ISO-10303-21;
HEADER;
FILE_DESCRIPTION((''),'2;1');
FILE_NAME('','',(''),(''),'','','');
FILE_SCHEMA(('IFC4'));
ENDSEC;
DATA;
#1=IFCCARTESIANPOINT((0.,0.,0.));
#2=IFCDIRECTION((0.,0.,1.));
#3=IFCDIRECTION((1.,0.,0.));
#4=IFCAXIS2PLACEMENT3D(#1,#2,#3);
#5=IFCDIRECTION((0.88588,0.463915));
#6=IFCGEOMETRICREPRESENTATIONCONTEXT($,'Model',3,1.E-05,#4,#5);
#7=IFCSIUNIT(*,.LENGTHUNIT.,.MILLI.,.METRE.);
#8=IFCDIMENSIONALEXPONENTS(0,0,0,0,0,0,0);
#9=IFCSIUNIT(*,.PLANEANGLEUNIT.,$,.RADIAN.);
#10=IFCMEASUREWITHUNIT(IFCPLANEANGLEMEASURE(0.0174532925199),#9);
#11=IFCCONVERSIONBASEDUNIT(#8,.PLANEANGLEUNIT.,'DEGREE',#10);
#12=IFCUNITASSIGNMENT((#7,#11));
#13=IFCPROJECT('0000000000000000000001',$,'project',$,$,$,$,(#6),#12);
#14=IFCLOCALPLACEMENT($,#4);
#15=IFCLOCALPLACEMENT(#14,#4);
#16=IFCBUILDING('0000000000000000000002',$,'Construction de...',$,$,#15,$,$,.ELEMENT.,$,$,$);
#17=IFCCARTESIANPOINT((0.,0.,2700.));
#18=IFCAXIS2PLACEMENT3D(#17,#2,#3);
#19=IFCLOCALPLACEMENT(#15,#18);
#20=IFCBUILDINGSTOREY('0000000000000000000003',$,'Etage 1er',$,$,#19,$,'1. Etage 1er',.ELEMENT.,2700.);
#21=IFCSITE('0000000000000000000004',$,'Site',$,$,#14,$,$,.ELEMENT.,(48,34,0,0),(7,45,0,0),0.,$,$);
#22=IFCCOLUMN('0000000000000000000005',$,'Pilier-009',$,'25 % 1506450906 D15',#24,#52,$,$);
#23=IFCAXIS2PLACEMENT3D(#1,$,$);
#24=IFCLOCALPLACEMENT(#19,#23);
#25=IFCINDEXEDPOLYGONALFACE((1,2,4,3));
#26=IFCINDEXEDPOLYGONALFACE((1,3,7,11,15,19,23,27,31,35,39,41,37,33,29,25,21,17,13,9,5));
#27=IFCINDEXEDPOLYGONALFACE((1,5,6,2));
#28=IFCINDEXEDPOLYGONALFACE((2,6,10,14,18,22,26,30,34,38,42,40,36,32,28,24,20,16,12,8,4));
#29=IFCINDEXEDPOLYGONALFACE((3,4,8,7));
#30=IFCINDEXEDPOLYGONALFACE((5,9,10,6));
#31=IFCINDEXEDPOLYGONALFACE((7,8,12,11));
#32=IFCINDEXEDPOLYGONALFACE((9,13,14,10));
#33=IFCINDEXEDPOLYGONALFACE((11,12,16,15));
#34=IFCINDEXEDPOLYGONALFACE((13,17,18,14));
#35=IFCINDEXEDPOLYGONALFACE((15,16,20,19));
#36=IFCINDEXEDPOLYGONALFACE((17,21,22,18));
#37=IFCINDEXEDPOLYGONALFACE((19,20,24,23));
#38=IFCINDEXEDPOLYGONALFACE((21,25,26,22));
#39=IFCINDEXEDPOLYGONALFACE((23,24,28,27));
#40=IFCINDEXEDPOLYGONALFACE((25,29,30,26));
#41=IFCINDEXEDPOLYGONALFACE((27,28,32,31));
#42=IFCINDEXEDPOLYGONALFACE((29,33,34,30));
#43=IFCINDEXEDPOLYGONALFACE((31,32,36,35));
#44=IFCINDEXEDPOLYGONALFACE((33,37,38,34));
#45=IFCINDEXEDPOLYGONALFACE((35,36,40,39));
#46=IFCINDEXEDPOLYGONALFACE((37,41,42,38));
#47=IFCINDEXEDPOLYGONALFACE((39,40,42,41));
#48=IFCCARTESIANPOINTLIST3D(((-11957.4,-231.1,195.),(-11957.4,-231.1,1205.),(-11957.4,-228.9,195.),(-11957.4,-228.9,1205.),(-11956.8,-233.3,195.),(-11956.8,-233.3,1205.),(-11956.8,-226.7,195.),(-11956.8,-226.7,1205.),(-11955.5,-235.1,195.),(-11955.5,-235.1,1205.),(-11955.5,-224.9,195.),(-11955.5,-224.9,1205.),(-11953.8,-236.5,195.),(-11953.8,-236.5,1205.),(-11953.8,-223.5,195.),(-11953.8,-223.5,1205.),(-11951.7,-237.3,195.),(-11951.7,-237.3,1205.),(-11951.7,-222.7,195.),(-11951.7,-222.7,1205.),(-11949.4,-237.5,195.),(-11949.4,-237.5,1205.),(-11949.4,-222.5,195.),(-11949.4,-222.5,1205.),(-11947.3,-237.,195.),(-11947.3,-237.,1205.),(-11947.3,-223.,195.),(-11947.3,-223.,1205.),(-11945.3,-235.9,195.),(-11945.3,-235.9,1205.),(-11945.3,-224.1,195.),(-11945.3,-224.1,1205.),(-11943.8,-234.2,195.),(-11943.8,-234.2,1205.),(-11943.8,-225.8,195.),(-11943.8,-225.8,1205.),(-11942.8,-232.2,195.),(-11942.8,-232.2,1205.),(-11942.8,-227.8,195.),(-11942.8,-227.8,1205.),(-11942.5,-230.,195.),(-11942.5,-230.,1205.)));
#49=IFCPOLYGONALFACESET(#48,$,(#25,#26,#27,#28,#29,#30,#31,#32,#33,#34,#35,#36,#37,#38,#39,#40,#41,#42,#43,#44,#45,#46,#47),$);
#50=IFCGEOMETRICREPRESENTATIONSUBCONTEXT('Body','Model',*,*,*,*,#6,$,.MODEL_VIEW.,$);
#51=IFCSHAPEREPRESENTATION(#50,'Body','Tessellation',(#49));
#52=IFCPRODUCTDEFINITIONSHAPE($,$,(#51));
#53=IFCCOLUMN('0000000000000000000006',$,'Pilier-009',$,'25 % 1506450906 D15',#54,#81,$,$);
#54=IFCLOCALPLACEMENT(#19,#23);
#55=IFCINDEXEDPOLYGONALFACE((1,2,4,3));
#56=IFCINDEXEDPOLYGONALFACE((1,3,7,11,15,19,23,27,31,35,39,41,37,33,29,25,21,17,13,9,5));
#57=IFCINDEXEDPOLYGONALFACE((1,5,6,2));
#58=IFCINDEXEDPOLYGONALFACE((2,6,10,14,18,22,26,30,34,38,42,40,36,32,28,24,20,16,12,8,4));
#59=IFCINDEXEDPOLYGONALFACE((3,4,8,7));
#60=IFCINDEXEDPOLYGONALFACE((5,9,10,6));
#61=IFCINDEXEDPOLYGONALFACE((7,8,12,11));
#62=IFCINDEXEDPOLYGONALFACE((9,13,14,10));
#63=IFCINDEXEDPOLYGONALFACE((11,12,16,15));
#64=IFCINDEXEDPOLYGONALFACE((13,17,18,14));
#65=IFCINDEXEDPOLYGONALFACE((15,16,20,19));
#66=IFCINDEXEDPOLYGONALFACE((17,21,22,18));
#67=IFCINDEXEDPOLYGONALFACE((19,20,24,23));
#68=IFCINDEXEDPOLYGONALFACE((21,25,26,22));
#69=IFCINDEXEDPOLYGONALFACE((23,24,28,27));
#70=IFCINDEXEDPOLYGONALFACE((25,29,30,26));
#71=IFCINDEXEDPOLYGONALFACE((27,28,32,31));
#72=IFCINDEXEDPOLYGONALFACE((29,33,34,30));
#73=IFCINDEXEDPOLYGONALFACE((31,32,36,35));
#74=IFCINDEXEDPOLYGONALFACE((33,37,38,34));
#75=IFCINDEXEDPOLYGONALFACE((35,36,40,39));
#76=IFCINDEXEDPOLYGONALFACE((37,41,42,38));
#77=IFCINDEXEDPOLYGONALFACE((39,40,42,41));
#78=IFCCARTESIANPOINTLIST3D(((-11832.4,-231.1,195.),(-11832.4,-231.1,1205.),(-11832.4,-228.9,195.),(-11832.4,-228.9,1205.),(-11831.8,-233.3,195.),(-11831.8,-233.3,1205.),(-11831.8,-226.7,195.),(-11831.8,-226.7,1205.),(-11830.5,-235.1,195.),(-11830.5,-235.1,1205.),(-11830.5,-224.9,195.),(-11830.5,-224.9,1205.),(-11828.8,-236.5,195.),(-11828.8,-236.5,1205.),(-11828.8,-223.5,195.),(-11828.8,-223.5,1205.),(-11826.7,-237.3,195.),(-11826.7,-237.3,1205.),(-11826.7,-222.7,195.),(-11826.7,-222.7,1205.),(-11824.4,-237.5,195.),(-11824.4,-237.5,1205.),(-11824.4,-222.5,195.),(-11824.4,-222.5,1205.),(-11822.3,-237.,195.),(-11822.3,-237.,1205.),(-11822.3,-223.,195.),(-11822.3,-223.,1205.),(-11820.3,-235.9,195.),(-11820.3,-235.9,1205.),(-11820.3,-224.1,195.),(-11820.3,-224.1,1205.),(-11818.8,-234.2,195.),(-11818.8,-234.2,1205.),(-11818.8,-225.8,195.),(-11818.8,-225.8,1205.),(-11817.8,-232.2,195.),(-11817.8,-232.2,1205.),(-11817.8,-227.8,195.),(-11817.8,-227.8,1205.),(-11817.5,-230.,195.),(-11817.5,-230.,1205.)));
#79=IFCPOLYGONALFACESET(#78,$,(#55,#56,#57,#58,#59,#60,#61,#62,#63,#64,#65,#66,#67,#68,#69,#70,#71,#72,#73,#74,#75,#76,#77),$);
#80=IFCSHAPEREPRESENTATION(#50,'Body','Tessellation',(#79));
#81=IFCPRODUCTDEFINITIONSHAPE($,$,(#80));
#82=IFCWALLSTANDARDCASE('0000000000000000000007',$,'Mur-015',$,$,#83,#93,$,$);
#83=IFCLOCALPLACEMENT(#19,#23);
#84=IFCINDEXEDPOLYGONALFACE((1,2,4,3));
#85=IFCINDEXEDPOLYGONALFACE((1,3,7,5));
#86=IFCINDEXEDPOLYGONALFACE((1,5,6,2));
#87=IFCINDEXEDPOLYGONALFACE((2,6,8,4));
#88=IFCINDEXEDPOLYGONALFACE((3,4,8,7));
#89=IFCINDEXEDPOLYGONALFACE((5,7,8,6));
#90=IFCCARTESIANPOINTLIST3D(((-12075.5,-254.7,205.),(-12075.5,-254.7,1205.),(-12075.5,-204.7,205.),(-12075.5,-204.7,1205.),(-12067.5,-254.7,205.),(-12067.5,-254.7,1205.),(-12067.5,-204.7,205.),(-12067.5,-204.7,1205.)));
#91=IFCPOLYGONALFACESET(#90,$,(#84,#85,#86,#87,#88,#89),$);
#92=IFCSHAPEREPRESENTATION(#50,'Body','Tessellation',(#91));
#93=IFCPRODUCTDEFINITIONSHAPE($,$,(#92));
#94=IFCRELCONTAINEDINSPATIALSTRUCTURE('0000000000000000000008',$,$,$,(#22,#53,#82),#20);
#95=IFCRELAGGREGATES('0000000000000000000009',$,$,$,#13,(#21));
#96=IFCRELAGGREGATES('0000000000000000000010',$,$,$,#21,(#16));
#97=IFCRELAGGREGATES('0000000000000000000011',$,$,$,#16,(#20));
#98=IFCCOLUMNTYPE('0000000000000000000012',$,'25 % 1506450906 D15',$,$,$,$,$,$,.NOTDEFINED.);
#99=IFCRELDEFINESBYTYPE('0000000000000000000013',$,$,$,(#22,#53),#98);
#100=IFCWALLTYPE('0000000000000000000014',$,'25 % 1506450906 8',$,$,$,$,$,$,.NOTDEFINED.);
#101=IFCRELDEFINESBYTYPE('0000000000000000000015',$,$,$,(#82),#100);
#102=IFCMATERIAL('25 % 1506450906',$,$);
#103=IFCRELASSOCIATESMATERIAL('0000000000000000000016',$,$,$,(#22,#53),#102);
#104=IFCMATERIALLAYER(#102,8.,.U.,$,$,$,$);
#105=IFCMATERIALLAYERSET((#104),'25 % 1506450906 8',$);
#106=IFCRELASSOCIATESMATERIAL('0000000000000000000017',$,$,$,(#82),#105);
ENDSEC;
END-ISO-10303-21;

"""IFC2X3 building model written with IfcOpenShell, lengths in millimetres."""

from ifc_helpers import new_model, entity, si_unit, converted_unit, direction, frame, origin_with_axes, origin_2d_with_axis, place, context, subcontext, project, spatial, polyline, circle, outline, extrude, material, layer, layer_set, layer_usage, type_object, element, save


model = new_model("IFC2X3")

# Units and contexts
model_context = context("Model", 3, precision=1e-05, world=origin_with_axes(), true_north=direction((0.88588, 0.463915)))
body_context = subcontext(model_context, "Body", "Model", "MODEL_VIEW")
ifc_project = project(units=[si_unit("LENGTHUNIT", "METRE", prefix="MILLI"), converted_unit("PLANEANGLEUNIT", "DEGREE", entity("IfcPlaneAngleMeasure", 0.0174532925199), si_unit("PLANEANGLEUNIT", "RADIAN"), dimensions=[0, 0, 0, 0, 0, 0, 0])], contexts=[model_context])

# Site, building, storey
site_placement = place(None, origin_with_axes())
site = spatial("IfcSite", under=ifc_project, at=site_placement, Name="Site", CompositionType="ELEMENT", RefLatitude=(48, 34, 0, 0), RefLongitude=(7, 45, 0, 0), RefElevation=0.0)
building_placement = place(site_placement, origin_with_axes())
building = spatial("IfcBuilding", under=site, at=building_placement, Name="Construction de...", CompositionType="ELEMENT")
storey_placement = place(building_placement, frame((0.0, 0.0, 2700.0), z_axis=(0.0, 0.0, 1.0), x_axis=(1.0, 0.0, 0.0)))
storey = spatial("IfcBuildingStorey", under=building, at=storey_placement, Name="Etage 1er", LongName="1. Etage 1er", CompositionType="ELEMENT", Elevation=2700.0)

# Columns
ifc_material = material(Name="25 % 1506450906")
column_type = type_object("IfcColumnType", Name="25 % 1506450906 D15", PredefinedType="NOTDEFINED")
for number, where, z_axis, x_axis, name in (
    (1, (-11950.0, -230.0, 195.0), (0.0, 0.0, 1.0), (1.0, 0.0, 0.0), "Pilier-009"),
    (2, (-11825.0, -230.0, 195.0), (0.0, 0.0, 1.0), (1.0, 0.0, 0.0), "Pilier-009"),
):
    element("IfcColumn", number, at=place(storey_placement, frame(where, z_axis=z_axis, x_axis=x_axis)), inside=storey, type_object=column_type, material=ifc_material, Name=name, ObjectType="25 % 1506450906 D15", context=body_context, shape_type="SweptSolid", body=[
        extrude(circle(Radius=7.5, at=origin_2d_with_axis()), origin_with_axes(), (0.0, 0.0, 1.0), 1010.0),
    ])

# Wall
ifc_layer = layer(ifc_material, 8.0, ventilated="UNKNOWN")
ifc_layer_set = layer_set([ifc_layer], Name="25 % 1506450906 8")
ifc_layer_usage = layer_usage(ifc_layer_set, "AXIS2", "NEGATIVE", 4.0)
wall_type = type_object("IfcWallType", Name="25 % 1506450906 8", PredefinedType="NOTDEFINED")
wall_placement = place(storey_placement, frame((-12071.5, -254.7, 205.0), z_axis=(0.0, 0.0, 1.0), x_axis=(0.0, 1.0, 0.0)))
element("IfcWallStandardCase", 3, at=wall_placement, inside=storey, type_object=wall_type, material=ifc_layer_usage, Name="Mur-015", context=body_context, shape_type="SweptSolid", body=[
    extrude(outline(polyline([(0.0, -4.0), (50.0, -4.0), (50.0, 4.0), (0.0, 4.0), (0.0, -4.0)])), origin_with_axes(), (0.0, 0.0, 1.0), 1000.0),
])

save(model, "model.ifc")
